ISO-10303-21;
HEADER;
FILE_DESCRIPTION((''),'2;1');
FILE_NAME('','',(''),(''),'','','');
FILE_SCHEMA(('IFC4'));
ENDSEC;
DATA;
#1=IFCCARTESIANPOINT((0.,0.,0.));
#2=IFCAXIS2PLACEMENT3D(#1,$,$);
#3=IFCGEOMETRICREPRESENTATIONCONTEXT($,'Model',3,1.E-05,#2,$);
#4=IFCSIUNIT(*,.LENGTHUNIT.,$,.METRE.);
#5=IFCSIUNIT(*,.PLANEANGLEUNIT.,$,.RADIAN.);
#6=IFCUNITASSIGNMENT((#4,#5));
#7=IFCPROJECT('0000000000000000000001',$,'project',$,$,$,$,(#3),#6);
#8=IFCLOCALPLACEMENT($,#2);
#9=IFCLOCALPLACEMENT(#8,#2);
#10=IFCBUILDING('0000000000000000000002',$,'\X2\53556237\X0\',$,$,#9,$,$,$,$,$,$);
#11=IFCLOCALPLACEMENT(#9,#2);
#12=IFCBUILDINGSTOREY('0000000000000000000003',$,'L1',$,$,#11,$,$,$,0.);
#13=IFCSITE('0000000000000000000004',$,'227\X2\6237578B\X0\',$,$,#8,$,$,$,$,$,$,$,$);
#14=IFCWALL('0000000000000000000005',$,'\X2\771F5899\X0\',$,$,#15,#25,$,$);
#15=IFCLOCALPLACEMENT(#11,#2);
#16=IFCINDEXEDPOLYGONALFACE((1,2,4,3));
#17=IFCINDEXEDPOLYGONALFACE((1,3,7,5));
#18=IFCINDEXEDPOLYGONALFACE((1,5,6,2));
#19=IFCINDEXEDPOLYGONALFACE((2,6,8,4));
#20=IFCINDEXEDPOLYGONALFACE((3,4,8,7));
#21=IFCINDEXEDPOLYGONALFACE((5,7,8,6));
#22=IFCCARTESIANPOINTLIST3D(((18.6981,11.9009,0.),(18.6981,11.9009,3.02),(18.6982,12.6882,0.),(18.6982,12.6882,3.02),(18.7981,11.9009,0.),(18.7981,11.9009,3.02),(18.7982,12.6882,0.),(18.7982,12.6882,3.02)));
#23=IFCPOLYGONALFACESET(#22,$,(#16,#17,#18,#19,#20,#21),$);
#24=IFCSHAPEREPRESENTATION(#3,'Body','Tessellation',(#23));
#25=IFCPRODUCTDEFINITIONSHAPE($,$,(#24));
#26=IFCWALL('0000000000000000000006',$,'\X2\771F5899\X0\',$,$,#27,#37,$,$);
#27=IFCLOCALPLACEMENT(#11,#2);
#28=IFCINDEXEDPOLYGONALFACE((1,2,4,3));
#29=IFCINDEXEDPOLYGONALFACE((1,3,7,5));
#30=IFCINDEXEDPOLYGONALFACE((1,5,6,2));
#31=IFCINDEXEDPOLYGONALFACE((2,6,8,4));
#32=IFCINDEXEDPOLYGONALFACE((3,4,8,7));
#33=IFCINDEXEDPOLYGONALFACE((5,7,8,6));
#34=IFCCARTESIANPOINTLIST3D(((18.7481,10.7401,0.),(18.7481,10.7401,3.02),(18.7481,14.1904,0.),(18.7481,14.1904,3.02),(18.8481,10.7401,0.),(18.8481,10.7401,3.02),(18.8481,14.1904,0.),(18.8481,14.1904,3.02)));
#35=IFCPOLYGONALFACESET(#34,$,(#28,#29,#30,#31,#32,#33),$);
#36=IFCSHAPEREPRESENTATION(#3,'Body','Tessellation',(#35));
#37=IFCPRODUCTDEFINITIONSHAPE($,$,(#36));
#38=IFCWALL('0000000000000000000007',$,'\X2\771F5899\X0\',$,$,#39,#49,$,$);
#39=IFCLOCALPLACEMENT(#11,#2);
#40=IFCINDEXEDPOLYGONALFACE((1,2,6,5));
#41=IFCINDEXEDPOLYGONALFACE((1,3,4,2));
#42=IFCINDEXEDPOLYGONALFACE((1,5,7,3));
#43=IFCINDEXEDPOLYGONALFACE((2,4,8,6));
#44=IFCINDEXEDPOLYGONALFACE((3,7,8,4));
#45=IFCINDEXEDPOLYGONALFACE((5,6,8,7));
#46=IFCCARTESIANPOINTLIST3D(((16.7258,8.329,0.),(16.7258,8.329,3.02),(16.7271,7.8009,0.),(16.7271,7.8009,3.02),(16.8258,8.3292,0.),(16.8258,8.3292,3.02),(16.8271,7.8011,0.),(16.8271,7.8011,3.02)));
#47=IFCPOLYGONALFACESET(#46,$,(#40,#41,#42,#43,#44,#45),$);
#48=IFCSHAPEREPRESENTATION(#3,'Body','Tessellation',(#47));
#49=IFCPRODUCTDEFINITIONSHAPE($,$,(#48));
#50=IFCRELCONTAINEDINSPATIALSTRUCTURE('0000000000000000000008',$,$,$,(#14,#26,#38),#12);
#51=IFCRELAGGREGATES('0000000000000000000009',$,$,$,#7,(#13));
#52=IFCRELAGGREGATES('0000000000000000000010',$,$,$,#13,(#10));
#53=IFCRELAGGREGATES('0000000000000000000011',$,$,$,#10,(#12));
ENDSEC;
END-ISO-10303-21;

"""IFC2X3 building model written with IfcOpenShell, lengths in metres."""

from ifc_helpers import new_model, si_unit, origin, place, context, project, spatial, polyline, outline, extrude, element, save


model = new_model("IFC2X3")

# Units and contexts
model_context = context("Model", 3, precision=1e-05, world=origin())
ifc_project = project(units=[si_unit("LENGTHUNIT", "METRE"), si_unit("PLANEANGLEUNIT", "RADIAN")], contexts=[model_context])

# Site, building, storey
site_placement = place(None, origin())
site = spatial("IfcSite", under=ifc_project, at=site_placement, Name="227户型")
building_placement = place(site_placement, origin())
building = spatial("IfcBuilding", under=site, at=building_placement, Name="单户")
storey_placement = place(building_placement, origin())
storey = spatial("IfcBuildingStorey", under=building, at=storey_placement, Name="L1", Elevation=0.0)

# Walls
wall_1_placement = place(storey_placement, origin())
element("IfcWall", 1, at=wall_1_placement, inside=storey, Name="真墙", context=model_context, shape_type="SweptSolid", body=[
    extrude(outline(polyline([(18.7982, 12.6882), (18.7981, 11.9009), (18.6981, 11.9009), (18.6982, 12.6882), (18.7982, 12.6882)])), origin(), (0.0, 0.0, 1.0), 3.02),
])
wall_2_placement = place(storey_placement, origin())
element("IfcWall", 2, at=wall_2_placement, inside=storey, Name="真墙", context=model_context, shape_type="SweptSolid", body=[
    extrude(outline(polyline([(18.7481, 10.7401), (18.7481, 14.1904), (18.8481, 14.1904), (18.8481, 10.7401), (18.7481, 10.7401)])), origin(), (0.0, 0.0, 1.0), 3.02),
])
wall_3_placement = place(storey_placement, origin())
element("IfcWall", 3, at=wall_3_placement, inside=storey, Name="真墙", context=model_context, shape_type="SweptSolid", body=[
    extrude(outline(polyline([(16.7271, 7.8009), (16.7258, 8.329), (16.8258, 8.3292), (16.8271, 7.8011), (16.7271, 7.8009)])), origin(), (0.0, 0.0, 1.0), 3.02),
])

save(model, "model.ifc")
